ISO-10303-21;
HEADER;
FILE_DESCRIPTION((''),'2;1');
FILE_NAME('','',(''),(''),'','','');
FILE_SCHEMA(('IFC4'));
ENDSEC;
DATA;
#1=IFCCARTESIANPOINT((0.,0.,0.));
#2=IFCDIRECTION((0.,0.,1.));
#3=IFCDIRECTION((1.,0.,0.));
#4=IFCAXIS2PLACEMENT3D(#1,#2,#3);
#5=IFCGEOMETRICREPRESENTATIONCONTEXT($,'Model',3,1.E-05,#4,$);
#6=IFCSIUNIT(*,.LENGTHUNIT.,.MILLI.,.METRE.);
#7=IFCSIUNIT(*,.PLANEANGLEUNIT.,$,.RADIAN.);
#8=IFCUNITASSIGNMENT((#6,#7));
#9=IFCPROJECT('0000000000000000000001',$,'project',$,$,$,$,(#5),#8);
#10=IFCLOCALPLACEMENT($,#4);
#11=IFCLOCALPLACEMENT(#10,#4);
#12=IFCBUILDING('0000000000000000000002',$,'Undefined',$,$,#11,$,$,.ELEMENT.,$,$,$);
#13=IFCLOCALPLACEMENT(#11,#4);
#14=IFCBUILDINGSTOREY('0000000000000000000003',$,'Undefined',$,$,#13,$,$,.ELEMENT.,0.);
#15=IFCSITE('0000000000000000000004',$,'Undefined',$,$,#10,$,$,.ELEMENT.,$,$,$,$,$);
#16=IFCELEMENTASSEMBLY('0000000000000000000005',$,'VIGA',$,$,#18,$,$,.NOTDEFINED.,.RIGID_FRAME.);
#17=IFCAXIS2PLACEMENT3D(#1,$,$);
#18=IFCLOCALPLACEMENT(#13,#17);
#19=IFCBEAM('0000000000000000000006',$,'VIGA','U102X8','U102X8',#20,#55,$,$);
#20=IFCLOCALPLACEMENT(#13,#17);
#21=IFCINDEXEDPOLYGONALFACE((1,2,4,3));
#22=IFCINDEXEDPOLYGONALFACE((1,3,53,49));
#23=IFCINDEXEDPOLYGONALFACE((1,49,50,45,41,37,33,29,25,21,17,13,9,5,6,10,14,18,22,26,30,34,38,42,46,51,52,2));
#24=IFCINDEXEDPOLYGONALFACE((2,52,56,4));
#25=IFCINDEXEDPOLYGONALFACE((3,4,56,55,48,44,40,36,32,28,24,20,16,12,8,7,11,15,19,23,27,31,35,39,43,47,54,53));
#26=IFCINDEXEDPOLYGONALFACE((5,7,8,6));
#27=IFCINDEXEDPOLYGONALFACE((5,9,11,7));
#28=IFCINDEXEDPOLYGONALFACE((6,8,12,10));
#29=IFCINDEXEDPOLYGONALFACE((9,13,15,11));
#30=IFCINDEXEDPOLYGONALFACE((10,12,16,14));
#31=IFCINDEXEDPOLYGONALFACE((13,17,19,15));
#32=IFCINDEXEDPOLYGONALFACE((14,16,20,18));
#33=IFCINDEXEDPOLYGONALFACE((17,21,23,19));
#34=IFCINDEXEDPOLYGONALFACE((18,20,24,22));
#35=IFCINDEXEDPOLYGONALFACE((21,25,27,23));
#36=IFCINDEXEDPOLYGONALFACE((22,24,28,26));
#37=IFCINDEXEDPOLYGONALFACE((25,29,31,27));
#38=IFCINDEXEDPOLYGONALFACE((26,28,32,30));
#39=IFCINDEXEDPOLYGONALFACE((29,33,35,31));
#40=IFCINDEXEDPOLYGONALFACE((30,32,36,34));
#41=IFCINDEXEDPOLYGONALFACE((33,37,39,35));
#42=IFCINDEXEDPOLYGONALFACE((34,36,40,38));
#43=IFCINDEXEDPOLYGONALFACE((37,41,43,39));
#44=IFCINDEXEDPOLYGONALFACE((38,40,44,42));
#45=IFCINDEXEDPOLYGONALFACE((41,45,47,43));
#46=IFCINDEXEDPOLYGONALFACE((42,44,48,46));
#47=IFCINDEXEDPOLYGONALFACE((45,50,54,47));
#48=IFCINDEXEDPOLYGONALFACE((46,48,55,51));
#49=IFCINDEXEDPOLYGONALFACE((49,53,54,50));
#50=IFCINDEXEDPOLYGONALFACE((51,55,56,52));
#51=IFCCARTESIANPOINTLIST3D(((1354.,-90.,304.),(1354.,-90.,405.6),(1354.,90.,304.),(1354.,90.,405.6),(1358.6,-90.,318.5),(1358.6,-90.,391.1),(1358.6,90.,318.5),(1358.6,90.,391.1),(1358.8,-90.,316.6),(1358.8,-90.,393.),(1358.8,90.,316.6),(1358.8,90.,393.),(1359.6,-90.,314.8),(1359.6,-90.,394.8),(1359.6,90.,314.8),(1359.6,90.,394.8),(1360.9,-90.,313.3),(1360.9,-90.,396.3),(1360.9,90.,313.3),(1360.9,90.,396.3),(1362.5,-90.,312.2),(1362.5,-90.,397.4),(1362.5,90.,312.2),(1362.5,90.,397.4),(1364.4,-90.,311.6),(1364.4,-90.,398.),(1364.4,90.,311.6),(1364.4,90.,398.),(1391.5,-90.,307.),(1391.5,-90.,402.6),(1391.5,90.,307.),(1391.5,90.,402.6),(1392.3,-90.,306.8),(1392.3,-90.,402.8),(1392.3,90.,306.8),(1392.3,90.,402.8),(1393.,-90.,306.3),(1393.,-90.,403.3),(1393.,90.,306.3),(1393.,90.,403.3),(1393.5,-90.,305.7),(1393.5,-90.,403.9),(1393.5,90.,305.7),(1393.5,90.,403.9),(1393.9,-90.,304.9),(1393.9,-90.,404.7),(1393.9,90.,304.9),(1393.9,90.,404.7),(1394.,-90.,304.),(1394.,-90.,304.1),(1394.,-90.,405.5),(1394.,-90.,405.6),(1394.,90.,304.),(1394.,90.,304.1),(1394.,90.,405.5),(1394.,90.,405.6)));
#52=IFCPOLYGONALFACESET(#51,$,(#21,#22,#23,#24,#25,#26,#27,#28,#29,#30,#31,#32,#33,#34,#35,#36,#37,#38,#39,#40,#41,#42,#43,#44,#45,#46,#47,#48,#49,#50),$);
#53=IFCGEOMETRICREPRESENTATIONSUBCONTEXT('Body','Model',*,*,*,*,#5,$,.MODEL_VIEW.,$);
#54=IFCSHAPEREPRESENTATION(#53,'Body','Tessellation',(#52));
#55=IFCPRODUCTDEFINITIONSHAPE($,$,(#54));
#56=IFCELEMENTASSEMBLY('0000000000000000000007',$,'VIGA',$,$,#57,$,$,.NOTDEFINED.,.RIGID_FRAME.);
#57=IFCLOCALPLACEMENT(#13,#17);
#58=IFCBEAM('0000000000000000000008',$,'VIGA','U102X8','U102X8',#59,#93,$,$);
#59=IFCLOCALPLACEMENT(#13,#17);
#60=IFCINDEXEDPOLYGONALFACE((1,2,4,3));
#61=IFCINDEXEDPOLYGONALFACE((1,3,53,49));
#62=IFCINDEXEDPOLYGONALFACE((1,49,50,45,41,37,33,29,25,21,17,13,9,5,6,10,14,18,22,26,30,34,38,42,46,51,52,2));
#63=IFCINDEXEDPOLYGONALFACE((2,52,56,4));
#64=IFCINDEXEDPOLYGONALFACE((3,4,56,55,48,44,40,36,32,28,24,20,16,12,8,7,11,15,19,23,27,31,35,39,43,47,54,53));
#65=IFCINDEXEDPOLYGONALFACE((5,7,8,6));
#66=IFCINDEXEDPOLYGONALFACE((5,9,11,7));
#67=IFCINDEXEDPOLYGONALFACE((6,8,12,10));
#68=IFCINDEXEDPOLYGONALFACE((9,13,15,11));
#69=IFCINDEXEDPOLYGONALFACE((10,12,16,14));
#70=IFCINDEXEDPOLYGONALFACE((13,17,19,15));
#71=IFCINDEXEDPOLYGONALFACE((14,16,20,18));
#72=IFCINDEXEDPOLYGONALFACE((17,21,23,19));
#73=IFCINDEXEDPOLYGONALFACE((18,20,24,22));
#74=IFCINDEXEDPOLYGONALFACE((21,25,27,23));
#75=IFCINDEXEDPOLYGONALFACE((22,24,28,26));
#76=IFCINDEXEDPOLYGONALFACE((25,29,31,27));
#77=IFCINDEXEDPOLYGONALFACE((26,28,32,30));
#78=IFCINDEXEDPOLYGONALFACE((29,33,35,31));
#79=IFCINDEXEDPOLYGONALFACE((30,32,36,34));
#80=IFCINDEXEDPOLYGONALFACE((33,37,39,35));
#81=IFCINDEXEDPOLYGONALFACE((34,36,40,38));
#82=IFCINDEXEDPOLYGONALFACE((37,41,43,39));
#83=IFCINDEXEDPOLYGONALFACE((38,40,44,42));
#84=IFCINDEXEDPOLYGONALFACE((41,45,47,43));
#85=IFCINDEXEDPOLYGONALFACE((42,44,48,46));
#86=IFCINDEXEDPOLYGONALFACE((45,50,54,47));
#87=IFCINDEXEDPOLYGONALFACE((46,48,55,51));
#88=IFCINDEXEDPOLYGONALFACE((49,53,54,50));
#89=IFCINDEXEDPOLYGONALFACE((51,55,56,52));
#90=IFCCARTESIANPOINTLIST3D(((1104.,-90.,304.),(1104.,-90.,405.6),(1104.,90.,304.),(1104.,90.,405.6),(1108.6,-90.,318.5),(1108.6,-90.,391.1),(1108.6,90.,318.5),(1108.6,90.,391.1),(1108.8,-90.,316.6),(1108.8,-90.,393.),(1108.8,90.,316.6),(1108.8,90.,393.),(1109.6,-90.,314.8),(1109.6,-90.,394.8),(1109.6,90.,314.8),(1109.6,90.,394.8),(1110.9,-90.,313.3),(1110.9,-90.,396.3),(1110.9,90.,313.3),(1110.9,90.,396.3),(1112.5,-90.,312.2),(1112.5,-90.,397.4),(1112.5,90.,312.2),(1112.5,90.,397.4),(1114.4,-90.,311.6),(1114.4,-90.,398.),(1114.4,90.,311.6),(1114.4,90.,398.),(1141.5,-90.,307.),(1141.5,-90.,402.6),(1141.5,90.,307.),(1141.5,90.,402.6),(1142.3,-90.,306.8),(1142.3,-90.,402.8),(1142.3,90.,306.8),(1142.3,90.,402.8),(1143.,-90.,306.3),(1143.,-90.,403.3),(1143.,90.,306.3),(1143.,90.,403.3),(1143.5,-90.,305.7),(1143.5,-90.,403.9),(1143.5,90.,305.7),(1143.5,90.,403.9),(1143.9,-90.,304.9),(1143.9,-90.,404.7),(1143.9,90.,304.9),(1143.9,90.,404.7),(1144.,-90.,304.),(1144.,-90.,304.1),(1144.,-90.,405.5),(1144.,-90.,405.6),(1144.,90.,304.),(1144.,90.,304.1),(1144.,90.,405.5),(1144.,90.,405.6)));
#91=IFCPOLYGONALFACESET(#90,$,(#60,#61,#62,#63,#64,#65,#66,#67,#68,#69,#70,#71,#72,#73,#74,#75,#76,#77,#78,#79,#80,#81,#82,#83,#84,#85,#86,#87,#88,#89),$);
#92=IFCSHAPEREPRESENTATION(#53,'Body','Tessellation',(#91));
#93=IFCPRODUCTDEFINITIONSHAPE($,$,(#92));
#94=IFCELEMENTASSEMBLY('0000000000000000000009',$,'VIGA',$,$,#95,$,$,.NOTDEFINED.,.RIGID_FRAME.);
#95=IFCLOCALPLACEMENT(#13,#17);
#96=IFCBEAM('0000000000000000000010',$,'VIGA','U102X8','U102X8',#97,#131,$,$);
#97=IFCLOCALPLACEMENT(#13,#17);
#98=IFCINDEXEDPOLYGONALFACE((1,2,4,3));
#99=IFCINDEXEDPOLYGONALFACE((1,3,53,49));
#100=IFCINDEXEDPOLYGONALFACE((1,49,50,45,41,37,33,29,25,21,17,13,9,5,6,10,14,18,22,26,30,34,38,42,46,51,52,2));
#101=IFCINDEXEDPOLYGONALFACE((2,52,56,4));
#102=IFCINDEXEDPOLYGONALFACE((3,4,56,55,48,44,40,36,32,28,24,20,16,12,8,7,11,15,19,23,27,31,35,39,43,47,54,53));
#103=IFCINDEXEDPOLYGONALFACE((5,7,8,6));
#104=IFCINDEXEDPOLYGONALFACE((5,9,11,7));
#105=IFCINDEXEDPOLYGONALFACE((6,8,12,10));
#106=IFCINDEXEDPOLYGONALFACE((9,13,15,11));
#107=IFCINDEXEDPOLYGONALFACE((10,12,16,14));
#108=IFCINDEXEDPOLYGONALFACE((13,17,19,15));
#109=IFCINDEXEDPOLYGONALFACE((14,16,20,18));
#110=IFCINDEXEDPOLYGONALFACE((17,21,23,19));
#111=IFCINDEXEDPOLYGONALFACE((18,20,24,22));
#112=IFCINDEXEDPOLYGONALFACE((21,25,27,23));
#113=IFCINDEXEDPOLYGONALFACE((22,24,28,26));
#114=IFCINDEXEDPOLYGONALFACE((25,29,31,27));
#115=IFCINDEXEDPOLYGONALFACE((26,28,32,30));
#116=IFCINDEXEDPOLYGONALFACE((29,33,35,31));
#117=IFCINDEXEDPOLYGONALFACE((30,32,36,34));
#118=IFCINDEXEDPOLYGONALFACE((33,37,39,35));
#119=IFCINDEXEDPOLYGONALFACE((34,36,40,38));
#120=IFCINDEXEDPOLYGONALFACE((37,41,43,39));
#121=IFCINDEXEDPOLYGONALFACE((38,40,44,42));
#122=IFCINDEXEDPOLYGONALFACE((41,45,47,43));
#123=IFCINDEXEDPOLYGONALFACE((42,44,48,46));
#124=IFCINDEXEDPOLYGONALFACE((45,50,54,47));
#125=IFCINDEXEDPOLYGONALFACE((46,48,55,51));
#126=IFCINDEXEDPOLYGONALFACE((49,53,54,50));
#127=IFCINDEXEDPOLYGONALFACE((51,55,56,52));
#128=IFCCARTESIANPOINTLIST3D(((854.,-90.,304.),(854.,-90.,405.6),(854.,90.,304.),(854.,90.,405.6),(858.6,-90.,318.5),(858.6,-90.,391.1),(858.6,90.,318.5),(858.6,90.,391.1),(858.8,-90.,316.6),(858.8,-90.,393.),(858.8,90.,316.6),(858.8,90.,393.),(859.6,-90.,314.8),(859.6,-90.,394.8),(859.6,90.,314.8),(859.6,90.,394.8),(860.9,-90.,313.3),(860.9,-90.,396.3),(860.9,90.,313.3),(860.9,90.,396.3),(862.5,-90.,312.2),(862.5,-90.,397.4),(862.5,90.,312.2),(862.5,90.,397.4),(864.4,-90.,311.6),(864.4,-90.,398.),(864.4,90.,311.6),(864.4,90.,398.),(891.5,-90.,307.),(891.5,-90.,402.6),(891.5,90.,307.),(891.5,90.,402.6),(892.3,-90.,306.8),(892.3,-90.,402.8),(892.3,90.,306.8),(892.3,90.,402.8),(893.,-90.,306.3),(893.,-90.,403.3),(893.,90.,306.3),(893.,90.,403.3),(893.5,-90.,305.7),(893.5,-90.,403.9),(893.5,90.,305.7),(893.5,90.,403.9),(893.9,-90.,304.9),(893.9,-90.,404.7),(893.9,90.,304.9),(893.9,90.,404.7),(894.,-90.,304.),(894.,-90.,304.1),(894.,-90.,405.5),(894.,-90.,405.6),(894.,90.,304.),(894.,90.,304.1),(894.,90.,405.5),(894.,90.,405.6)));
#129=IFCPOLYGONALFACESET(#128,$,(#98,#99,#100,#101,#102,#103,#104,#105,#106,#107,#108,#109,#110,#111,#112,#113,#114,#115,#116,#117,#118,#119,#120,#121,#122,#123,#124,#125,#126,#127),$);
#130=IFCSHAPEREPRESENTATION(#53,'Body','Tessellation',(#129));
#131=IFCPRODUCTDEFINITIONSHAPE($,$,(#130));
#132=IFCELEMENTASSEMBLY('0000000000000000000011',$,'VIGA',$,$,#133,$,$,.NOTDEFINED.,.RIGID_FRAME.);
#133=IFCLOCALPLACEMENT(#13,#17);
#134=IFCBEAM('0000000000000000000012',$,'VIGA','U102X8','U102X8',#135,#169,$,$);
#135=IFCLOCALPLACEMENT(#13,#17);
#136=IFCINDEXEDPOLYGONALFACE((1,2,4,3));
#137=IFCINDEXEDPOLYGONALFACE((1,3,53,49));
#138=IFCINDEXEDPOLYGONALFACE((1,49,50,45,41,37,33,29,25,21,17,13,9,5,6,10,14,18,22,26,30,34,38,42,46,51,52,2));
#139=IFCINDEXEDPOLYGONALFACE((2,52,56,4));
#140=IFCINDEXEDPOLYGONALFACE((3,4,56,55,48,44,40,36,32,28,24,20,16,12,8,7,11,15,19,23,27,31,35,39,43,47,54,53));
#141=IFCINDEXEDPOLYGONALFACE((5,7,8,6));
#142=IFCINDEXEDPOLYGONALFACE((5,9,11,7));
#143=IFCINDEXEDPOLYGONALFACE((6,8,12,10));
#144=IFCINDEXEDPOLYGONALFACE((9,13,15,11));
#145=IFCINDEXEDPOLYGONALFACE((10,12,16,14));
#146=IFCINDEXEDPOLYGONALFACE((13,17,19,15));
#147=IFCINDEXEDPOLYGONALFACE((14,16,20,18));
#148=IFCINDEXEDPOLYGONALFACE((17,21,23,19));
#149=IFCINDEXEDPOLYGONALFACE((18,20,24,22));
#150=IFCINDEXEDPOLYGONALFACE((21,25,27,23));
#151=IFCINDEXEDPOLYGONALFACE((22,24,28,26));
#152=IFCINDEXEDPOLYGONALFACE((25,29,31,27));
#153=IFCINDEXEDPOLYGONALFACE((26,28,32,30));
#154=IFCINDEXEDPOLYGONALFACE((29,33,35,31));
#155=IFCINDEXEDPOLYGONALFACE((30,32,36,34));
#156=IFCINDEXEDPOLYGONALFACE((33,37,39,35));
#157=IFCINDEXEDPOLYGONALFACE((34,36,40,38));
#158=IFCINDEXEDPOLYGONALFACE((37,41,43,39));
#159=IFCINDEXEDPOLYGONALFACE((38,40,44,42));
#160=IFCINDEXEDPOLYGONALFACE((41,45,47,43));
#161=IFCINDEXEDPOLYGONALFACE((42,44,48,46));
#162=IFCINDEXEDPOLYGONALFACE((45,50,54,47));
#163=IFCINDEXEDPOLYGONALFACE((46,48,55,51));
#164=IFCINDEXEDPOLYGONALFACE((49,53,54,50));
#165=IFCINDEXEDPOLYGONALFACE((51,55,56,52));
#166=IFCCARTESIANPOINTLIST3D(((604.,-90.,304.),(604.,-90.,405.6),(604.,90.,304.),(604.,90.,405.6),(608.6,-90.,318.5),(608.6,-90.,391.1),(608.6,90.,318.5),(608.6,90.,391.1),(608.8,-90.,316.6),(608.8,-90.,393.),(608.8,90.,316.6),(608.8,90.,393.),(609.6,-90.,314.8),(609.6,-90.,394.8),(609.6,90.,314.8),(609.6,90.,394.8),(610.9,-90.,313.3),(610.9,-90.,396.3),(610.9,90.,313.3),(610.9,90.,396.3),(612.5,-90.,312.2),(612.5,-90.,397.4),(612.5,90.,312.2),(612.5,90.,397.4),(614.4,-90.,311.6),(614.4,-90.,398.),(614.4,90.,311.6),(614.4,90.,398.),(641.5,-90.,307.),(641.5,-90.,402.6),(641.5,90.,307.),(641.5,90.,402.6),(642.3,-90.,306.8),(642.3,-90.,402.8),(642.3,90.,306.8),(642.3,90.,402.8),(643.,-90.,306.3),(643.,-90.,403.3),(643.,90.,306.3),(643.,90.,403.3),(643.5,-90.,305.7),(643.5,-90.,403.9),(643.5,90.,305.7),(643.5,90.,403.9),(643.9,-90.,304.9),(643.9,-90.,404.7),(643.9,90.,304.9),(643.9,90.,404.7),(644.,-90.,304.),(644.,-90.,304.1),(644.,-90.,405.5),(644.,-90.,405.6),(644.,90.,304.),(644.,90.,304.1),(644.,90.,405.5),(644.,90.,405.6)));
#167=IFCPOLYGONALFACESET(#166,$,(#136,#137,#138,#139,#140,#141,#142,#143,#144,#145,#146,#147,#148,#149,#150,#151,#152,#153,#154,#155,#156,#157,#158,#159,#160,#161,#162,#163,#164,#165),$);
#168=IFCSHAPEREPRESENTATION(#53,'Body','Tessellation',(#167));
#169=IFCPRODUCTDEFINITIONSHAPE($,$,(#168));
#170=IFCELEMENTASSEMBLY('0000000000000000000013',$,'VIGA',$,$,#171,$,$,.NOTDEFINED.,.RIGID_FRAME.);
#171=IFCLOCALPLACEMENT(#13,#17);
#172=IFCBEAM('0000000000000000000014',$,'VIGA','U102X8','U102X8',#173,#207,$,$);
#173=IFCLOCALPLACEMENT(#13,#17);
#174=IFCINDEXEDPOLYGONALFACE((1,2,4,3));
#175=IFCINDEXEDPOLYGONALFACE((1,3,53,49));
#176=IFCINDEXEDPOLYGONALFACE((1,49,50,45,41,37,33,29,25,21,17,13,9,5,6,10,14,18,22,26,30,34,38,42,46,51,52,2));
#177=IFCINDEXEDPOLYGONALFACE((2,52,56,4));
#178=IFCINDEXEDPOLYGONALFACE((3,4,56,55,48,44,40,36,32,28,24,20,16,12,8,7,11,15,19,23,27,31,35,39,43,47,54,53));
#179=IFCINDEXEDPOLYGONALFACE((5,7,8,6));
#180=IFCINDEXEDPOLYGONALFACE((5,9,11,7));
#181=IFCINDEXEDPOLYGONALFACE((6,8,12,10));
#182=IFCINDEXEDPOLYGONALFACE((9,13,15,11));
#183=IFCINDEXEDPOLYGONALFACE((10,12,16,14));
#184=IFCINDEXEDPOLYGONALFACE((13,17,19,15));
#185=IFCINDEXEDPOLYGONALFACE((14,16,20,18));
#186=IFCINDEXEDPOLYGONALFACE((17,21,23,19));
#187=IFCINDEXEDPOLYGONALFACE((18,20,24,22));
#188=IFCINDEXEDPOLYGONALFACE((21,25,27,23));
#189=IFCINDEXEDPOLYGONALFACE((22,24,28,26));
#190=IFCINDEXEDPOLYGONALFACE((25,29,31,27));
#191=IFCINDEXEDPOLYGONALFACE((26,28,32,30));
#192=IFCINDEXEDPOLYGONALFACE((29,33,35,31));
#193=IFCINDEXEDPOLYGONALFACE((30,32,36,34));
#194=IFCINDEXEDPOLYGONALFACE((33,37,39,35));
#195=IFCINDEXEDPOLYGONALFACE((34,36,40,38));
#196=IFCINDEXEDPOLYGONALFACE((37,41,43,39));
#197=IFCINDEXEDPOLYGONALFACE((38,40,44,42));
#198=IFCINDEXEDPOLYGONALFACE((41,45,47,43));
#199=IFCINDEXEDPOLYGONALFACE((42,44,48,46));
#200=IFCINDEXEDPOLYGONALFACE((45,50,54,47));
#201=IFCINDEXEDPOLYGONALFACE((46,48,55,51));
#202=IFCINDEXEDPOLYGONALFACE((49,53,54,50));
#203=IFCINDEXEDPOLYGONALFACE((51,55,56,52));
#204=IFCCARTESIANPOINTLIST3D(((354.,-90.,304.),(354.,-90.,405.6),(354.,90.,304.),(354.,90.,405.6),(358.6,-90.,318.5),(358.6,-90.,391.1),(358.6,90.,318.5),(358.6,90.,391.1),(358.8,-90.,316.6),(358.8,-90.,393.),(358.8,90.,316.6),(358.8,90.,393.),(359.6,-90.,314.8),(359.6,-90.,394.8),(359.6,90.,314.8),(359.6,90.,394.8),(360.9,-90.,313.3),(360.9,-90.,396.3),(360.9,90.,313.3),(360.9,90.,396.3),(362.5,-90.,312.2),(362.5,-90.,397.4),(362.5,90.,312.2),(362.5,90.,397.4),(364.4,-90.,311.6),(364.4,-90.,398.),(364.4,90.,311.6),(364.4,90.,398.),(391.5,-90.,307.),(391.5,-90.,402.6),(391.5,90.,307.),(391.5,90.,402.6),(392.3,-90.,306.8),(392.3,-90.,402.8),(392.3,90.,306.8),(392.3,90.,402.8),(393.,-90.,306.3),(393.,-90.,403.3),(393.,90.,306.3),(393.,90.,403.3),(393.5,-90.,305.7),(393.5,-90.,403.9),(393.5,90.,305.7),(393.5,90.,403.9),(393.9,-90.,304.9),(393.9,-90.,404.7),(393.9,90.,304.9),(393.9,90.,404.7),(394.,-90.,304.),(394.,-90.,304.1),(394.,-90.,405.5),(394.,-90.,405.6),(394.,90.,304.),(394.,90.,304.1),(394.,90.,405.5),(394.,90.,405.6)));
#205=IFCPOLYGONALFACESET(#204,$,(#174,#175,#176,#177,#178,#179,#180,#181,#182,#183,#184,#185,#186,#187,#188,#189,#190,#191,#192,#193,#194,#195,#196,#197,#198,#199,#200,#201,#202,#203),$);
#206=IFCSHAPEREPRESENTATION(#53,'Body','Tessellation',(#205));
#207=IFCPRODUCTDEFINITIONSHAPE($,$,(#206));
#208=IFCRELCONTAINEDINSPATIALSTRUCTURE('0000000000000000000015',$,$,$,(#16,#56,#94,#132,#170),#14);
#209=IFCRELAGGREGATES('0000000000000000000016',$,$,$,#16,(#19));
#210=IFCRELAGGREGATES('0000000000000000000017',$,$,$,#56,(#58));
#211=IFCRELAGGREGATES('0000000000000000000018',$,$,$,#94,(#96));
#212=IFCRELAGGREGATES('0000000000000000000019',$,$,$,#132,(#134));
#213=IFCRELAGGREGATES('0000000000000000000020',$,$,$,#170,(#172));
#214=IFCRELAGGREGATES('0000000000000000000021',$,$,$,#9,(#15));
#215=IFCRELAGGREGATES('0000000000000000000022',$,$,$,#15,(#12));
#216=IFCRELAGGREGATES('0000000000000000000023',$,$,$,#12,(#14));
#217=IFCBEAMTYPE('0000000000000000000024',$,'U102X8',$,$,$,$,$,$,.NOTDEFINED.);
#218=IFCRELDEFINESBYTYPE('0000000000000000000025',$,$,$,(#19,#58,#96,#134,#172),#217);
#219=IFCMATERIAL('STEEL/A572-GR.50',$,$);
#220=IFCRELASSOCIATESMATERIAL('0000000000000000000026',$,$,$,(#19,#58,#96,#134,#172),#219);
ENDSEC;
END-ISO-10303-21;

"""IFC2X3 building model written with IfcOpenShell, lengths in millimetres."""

from ifc_helpers import new_model, si_unit, frame, origin_with_axes, origin_2d_with_axis, place, context, subcontext, project, spatial, u_section, extrude, material, type_object, element, aggregate, save


model = new_model("IFC2X3")

# Units and contexts
model_context = context("Model", 3, precision=1e-05, world=origin_with_axes())
body_context = subcontext(model_context, "Body", "Model", "MODEL_VIEW")
ifc_project = project(units=[si_unit("LENGTHUNIT", "METRE", prefix="MILLI"), si_unit("PLANEANGLEUNIT", "RADIAN")], contexts=[model_context])

# Site, building, storey
site_placement = place(None, origin_with_axes())
site = spatial("IfcSite", under=ifc_project, at=site_placement, Name="Undefined", CompositionType="ELEMENT")
building_placement = place(site_placement, origin_with_axes())
building = spatial("IfcBuilding", under=site, at=building_placement, Name="Undefined", CompositionType="ELEMENT")
storey_placement = place(building_placement, origin_with_axes())
storey = spatial("IfcBuildingStorey", under=building, at=storey_placement, Name="Undefined", CompositionType="ELEMENT", Elevation=0.0)

# Element assemblies, beams
ifc_material_1 = material(Name="STEEL/A572-GR.50")
beam_type_1 = type_object("IfcBeamType", Name="U102X8", PredefinedType="NOTDEFINED")
assembly_1_placement = place(storey_placement, origin_with_axes())
assembly_1 = element("IfcElementAssembly", 1, at=assembly_1_placement, inside=storey, Name="VIGA", AssemblyPlace="NOTDEFINED", PredefinedType="RIGID_FRAME")
beam_1_placement = place(assembly_1_placement, frame((1374.0, -90.0, 354.8), z_axis=(0.0, 0.0, 1.0), x_axis=(0.0, 1.0, 0.0)))
beam_1 = element("IfcBeam", 2, at=beam_1_placement, type_object=beam_type_1, material=ifc_material_1, Name="VIGA", Description="U102X8", ObjectType="U102X8", context=body_context, shape_type="SweptSolid", body=[
    extrude(u_section(Depth=101.6, FlangeWidth=40.0, WebThickness=4.6, FlangeThickness=6.0, FilletRadius=7.0, EdgeRadius=3.0, FlangeSlope=0.16839, at=origin_2d_with_axis()), frame((180.0, 0.0, 0.0), z_axis=(-1.0, 0.0, 0.0), x_axis=(0.0, -1.0, 0.0)), (0.0, 0.0, 1.0), 180.0),
])
aggregate(assembly_1, [beam_1])
assembly_2_placement = place(storey_placement, origin_with_axes())
assembly_2 = element("IfcElementAssembly", 3, at=assembly_2_placement, inside=storey, Name="VIGA", AssemblyPlace="NOTDEFINED", PredefinedType="RIGID_FRAME")
beam_2_placement = place(assembly_2_placement, frame((1124.0, -90.0, 354.8), z_axis=(0.0, 0.0, 1.0), x_axis=(0.0, 1.0, 0.0)))
beam_2 = element("IfcBeam", 4, at=beam_2_placement, type_object=beam_type_1, material=ifc_material_1, Name="VIGA", Description="U102X8", ObjectType="U102X8", context=body_context, shape_type="SweptSolid", body=[
    extrude(u_section(Depth=101.6, FlangeWidth=40.0, WebThickness=4.6, FlangeThickness=6.0, FilletRadius=7.0, EdgeRadius=3.0, FlangeSlope=0.16839, at=origin_2d_with_axis()), frame((180.0, 0.0, 0.0), z_axis=(-1.0, 0.0, 0.0), x_axis=(0.0, -1.0, 0.0)), (0.0, 0.0, 1.0), 180.0),
])
aggregate(assembly_2, [beam_2])
assembly_3_placement = place(storey_placement, origin_with_axes())
assembly_3 = element("IfcElementAssembly", 5, at=assembly_3_placement, inside=storey, Name="VIGA", AssemblyPlace="NOTDEFINED", PredefinedType="RIGID_FRAME")
beam_3_placement = place(assembly_3_placement, frame((874.0, -90.0, 354.8), z_axis=(0.0, 0.0, 1.0), x_axis=(0.0, 1.0, 0.0)))
beam_3 = element("IfcBeam", 6, at=beam_3_placement, type_object=beam_type_1, material=ifc_material_1, Name="VIGA", Description="U102X8", ObjectType="U102X8", context=body_context, shape_type="SweptSolid", body=[
    extrude(u_section(Depth=101.6, FlangeWidth=40.0, WebThickness=4.6, FlangeThickness=6.0, FilletRadius=7.0, EdgeRadius=3.0, FlangeSlope=0.16839, at=origin_2d_with_axis()), frame((180.0, 0.0, 0.0), z_axis=(-1.0, 0.0, 0.0), x_axis=(0.0, -1.0, 0.0)), (0.0, 0.0, 1.0), 180.0),
])
aggregate(assembly_3, [beam_3])
assembly_4_placement = place(storey_placement, origin_with_axes())
assembly_4 = element("IfcElementAssembly", 7, at=assembly_4_placement, inside=storey, Name="VIGA", AssemblyPlace="NOTDEFINED", PredefinedType="RIGID_FRAME")
beam_4_placement = place(assembly_4_placement, frame((624.0, -90.0, 354.8), z_axis=(0.0, 0.0, 1.0), x_axis=(0.0, 1.0, 0.0)))
beam_4 = element("IfcBeam", 8, at=beam_4_placement, type_object=beam_type_1, material=ifc_material_1, Name="VIGA", Description="U102X8", ObjectType="U102X8", context=body_context, shape_type="SweptSolid", body=[
    extrude(u_section(Depth=101.6, FlangeWidth=40.0, WebThickness=4.6, FlangeThickness=6.0, FilletRadius=7.0, EdgeRadius=3.0, FlangeSlope=0.16839, at=origin_2d_with_axis()), frame((180.0, 0.0, 0.0), z_axis=(-1.0, 0.0, 0.0), x_axis=(0.0, -1.0, 0.0)), (0.0, 0.0, 1.0), 180.0),
])
aggregate(assembly_4, [beam_4])
assembly_5_placement = place(storey_placement, origin_with_axes())
assembly_5 = element("IfcElementAssembly", 9, at=assembly_5_placement, inside=storey, Name="VIGA", AssemblyPlace="NOTDEFINED", PredefinedType="RIGID_FRAME")
beam_5_placement = place(assembly_5_placement, frame((374.0, -90.0, 354.8), z_axis=(0.0, 0.0, 1.0), x_axis=(0.0, 1.0, 0.0)))
beam_5 = element("IfcBeam", 10, at=beam_5_placement, type_object=beam_type_1, material=ifc_material_1, Name="VIGA", Description="U102X8", ObjectType="U102X8", context=body_context, shape_type="SweptSolid", body=[
    extrude(u_section(Depth=101.6, FlangeWidth=40.0, WebThickness=4.6, FlangeThickness=6.0, FilletRadius=7.0, EdgeRadius=3.0, FlangeSlope=0.16839, at=origin_2d_with_axis()), frame((180.0, 0.0, 0.0), z_axis=(-1.0, 0.0, 0.0), x_axis=(0.0, -1.0, 0.0)), (0.0, 0.0, 1.0), 180.0),
])
aggregate(assembly_5, [beam_5])

save(model, "model.ifc")
